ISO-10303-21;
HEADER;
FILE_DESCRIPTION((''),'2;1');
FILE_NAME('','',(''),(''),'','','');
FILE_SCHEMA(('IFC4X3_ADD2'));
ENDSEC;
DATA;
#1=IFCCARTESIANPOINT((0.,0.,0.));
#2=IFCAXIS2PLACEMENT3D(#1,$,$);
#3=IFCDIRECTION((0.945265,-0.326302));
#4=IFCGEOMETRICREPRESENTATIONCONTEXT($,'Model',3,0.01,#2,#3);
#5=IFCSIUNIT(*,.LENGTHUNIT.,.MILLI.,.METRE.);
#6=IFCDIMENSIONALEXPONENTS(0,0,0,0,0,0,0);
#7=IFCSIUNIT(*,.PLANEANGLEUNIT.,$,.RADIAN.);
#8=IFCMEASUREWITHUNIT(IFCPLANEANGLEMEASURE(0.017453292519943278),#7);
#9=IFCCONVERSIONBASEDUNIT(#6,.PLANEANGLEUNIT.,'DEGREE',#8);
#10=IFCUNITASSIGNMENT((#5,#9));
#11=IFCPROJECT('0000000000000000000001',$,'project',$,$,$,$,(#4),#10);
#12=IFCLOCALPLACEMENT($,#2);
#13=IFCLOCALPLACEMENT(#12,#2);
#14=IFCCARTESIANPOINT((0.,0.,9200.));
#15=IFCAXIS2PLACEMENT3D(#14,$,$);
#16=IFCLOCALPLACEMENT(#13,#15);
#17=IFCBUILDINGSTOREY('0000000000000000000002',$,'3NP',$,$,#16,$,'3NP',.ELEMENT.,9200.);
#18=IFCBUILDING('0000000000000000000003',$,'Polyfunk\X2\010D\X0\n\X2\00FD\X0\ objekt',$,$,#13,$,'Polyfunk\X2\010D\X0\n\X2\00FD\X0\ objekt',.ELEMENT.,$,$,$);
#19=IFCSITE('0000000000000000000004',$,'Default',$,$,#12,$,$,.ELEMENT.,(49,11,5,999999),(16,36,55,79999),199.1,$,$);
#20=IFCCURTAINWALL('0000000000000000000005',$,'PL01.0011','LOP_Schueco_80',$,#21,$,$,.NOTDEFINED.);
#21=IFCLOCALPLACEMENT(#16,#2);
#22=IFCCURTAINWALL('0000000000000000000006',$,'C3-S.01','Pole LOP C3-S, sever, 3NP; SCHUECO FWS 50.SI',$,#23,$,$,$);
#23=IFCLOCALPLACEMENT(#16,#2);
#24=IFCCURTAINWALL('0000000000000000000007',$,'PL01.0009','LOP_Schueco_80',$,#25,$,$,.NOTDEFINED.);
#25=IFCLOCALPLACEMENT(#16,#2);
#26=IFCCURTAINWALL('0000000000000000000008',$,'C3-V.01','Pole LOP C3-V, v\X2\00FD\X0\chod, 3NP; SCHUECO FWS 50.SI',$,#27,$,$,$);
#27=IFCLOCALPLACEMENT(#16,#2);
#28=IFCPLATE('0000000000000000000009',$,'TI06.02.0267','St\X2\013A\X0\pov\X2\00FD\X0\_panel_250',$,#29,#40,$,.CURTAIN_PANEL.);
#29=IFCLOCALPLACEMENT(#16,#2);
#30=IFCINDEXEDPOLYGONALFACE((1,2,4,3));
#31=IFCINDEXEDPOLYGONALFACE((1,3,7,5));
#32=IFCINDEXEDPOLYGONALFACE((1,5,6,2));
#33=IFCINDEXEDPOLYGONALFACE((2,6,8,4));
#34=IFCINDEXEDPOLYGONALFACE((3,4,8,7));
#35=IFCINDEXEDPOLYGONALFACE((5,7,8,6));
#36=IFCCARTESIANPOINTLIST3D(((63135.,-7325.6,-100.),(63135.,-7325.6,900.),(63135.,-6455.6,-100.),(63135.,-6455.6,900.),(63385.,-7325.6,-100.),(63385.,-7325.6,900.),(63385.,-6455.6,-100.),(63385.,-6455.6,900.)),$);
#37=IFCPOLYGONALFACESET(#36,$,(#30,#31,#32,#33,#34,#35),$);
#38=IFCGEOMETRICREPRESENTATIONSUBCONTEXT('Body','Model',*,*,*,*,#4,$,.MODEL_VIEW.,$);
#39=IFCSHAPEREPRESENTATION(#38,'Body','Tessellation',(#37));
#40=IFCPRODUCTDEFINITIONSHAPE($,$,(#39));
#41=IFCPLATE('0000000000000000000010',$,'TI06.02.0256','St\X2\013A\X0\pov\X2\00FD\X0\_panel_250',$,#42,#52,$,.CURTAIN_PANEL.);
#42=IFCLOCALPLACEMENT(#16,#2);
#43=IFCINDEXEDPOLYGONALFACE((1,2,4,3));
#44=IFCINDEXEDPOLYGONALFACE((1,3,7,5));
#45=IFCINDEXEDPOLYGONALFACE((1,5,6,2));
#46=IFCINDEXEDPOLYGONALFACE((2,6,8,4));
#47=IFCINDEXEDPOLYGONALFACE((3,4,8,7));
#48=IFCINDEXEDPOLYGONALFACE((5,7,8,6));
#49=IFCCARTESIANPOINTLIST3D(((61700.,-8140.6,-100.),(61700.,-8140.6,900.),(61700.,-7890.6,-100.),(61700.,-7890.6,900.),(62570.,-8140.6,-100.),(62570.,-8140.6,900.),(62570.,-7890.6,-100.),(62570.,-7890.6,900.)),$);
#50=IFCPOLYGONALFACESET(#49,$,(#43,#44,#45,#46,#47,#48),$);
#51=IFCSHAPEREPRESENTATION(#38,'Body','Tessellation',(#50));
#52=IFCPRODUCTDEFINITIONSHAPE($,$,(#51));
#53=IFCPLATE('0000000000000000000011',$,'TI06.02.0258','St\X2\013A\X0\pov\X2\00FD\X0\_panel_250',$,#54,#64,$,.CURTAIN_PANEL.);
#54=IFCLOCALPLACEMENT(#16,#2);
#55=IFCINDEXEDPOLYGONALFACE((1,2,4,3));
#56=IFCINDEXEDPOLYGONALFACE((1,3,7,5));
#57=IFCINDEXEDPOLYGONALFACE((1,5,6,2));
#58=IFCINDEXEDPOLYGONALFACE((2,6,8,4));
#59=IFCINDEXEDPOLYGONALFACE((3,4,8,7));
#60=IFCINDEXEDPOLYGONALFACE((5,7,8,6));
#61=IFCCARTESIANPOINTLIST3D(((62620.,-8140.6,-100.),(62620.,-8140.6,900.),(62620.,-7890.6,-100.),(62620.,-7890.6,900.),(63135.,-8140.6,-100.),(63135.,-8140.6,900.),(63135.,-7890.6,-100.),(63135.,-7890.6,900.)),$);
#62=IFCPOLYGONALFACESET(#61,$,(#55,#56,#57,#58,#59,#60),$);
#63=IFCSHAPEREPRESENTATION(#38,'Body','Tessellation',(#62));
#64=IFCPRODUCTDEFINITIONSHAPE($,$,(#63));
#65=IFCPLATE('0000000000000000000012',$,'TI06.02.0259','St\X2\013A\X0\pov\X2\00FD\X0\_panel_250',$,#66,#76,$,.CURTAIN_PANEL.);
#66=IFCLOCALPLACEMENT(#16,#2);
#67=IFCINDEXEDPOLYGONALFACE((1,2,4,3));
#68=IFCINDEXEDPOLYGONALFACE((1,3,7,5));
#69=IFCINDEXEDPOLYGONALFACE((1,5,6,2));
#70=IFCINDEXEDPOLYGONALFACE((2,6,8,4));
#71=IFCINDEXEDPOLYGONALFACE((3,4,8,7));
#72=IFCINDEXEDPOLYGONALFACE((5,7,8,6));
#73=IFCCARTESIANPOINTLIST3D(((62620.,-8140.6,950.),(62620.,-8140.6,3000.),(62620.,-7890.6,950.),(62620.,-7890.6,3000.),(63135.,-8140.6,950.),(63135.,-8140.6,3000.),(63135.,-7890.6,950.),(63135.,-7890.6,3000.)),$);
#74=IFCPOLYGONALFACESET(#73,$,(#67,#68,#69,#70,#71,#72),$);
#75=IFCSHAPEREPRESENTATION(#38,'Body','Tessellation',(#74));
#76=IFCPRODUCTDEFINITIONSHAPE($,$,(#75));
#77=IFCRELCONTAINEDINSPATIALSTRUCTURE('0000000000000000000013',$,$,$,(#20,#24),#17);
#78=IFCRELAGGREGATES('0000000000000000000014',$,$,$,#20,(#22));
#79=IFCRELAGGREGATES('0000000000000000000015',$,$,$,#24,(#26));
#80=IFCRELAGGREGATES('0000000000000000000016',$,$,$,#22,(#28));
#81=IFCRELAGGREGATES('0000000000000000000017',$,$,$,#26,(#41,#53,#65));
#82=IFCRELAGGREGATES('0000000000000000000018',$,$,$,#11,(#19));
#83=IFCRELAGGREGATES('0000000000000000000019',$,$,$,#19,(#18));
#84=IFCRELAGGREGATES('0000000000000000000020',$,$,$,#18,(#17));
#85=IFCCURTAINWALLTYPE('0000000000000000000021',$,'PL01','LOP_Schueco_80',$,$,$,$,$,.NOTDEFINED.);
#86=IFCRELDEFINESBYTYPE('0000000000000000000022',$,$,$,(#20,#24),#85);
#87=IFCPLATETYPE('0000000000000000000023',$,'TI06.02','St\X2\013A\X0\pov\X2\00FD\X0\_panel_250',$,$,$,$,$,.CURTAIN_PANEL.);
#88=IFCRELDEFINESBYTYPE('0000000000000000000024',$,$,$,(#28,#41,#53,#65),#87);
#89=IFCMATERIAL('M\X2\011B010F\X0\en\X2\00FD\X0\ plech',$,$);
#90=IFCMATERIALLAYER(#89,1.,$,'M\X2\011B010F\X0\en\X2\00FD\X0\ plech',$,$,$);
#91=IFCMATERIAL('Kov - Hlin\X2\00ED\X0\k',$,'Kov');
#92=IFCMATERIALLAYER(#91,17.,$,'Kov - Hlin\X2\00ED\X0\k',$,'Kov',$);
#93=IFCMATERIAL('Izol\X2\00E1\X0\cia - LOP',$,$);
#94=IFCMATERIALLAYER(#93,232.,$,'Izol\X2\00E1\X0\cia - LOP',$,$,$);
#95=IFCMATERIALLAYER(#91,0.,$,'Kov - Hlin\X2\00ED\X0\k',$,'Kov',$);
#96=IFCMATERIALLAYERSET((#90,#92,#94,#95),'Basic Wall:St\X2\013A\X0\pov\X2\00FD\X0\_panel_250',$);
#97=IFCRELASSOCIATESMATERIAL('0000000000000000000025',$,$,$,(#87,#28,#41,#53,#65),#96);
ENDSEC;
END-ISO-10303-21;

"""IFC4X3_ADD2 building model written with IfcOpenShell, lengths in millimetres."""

from ifc_helpers import new_model, entity, si_unit, converted_unit, direction, frame, frame_2d, origin, place, context, subcontext, project, spatial, rectangle, extrude, material, layer, layer_set, layer_usage, type_object, element, aggregate, save


model = new_model("IFC4X3_ADD2")

# Units and contexts
model_context = context("Model", 3, precision=0.01, world=origin(), true_north=direction((0.945265, -0.326302)))
body_context = subcontext(model_context, "Body", "Model", "MODEL_VIEW")
ifc_project = project(units=[si_unit("LENGTHUNIT", "METRE", prefix="MILLI"), converted_unit("PLANEANGLEUNIT", "DEGREE", entity("IfcPlaneAngleMeasure", 0.017453292519943278), si_unit("PLANEANGLEUNIT", "RADIAN"), dimensions=[0, 0, 0, 0, 0, 0, 0])], contexts=[model_context])

# Site, building, storey
site_placement = place(None, origin())
site = spatial("IfcSite", under=ifc_project, at=site_placement, Name="Default", CompositionType="ELEMENT", RefLatitude=(49, 11, 5, 999999), RefLongitude=(16, 36, 55, 79999), RefElevation=199.1)
building_placement = place(site_placement, origin())
building = spatial("IfcBuilding", under=site, at=building_placement, Name="Polyfunkčný objekt", LongName="Polyfunkčný objekt", CompositionType="ELEMENT")
storey_placement = place(building_placement, frame((0.0, 0.0, 9200.0)))
storey = spatial("IfcBuildingStorey", under=building, at=storey_placement, Name="3NP", LongName="3NP", CompositionType="ELEMENT", Elevation=9200.0)

# Curtain walls
curtain_wall_type = type_object("IfcCurtainWallType", Name="PL01", Description="LOP_Schueco_80", PredefinedType="NOTDEFINED")
curtain_wall_1_placement = place(storey_placement, frame((0.0, 0.0, -9200.0)))
curtain_wall_1 = element("IfcCurtainWall", 1, at=curtain_wall_1_placement, inside=storey, type_object=curtain_wall_type, Name="PL01.0011", Description="LOP_Schueco_80", PredefinedType="NOTDEFINED")
curtain_wall_2 = element("IfcCurtainWall", 2, Name="C3-S.01", Description="Pole LOP C3-S, sever, 3NP; SCHUECO FWS 50.SI")
aggregate(curtain_wall_1, [curtain_wall_2])
curtain_wall_3_placement = place(storey_placement, frame((0.0, 0.0, -9200.0)))
curtain_wall_3 = element("IfcCurtainWall", 3, at=curtain_wall_3_placement, inside=storey, type_object=curtain_wall_type, Name="PL01.0009", Description="LOP_Schueco_80", PredefinedType="NOTDEFINED")
curtain_wall_4 = element("IfcCurtainWall", 4, Name="C3-V.01", Description="Pole LOP C3-V, východ, 3NP; SCHUECO FWS 50.SI")
aggregate(curtain_wall_3, [curtain_wall_4])

# Plates
ifc_material_1 = material(Name="Měďený plech")
ifc_layer_1 = layer(ifc_material_1, 1.0, Name="Měďený plech")
ifc_material_2 = material(Name="Kov - Hliník", Category="Kov")
ifc_layer_2 = layer(ifc_material_2, 17.0, Name="Kov - Hliník", Category="Kov")
ifc_material_3 = material(Name="Izolácia - LOP")
ifc_layer_3 = layer(ifc_material_3, 232.0, Name="Izolácia - LOP")
ifc_layer_4 = layer(ifc_material_2, 0.0, Name="Kov - Hliník", Category="Kov")
ifc_layer_set = layer_set([ifc_layer_1, ifc_layer_2, ifc_layer_3, ifc_layer_4], Name="Basic Wall:Stĺpový_panel_250")
ifc_layer_usage_1 = layer_usage(ifc_layer_set, "AXIS2", "NEGATIVE", 125.0)
plate_type = type_object("IfcPlateType", Name="TI06.02", Description="Stĺpový_panel_250", PredefinedType="CURTAIN_PANEL", material=ifc_layer_set)
plate_1_placement = place(storey_placement, frame((63260.0, -6455.6, -100.0), z_axis=(0.0, 0.0, 1.0), x_axis=(0.0, -1.0, 0.0)))
plate_1 = element("IfcPlate", 5, at=plate_1_placement, type_object=plate_type, material=ifc_layer_usage_1, Name="TI06.02.0267", Description="Stĺpový_panel_250", PredefinedType="CURTAIN_PANEL", context=body_context, shape_type="SweptSolid", body=[
    extrude(rectangle(XDim=250.0, YDim=870.0, at=frame_2d((0.0, 0.0), x_axis=(1.0, 0.0))), frame((435.0, 0.0, 0.0), z_axis=(0.0, 0.0, 1.0), x_axis=(0.0, 1.0, 0.0)), (0.0, 0.0, 1.0), 1000.0),
])
aggregate(curtain_wall_2, [plate_1])
ifc_layer_usage_2 = layer_usage(ifc_layer_set, "AXIS2", "POSITIVE", -125.0)
plate_2_placement = place(storey_placement, frame((61700.0, -8015.6, -100.0)))
plate_2 = element("IfcPlate", 6, at=plate_2_placement, type_object=plate_type, material=ifc_layer_usage_2, Name="TI06.02.0256", Description="Stĺpový_panel_250", PredefinedType="CURTAIN_PANEL", context=body_context, shape_type="SweptSolid", body=[
    extrude(rectangle(XDim=250.0, YDim=870.0, at=frame_2d((0.0, 0.0), x_axis=(1.0, 0.0))), frame((435.0, 0.0, 0.0), z_axis=(0.0, 0.0, 1.0), x_axis=(0.0, 1.0, 0.0)), (0.0, 0.0, 1.0), 1000.0),
])
ifc_layer_usage_3 = layer_usage(ifc_layer_set, "AXIS2", "POSITIVE", -125.0)
plate_3_placement = place(storey_placement, frame((62620.0, -8015.6, -100.0)))
plate_3 = element("IfcPlate", 7, at=plate_3_placement, type_object=plate_type, material=ifc_layer_usage_3, Name="TI06.02.0258", Description="Stĺpový_panel_250", PredefinedType="CURTAIN_PANEL", context=body_context, shape_type="SweptSolid", body=[
    extrude(rectangle(XDim=250.0, YDim=515.0, at=frame_2d((0.0, 0.0), x_axis=(1.0, 0.0))), frame((257.5, 0.0, 0.0), z_axis=(0.0, 0.0, 1.0), x_axis=(0.0, 1.0, 0.0)), (0.0, 0.0, 1.0), 1000.0),
])
ifc_layer_usage_4 = layer_usage(ifc_layer_set, "AXIS2", "POSITIVE", -125.0)
plate_4_placement = place(storey_placement, frame((62620.0, -8015.6, 950.0)))
plate_4 = element("IfcPlate", 8, at=plate_4_placement, type_object=plate_type, material=ifc_layer_usage_4, Name="TI06.02.0259", Description="Stĺpový_panel_250", PredefinedType="CURTAIN_PANEL", context=body_context, shape_type="SweptSolid", body=[
    extrude(rectangle(XDim=250.0, YDim=515.0, at=frame_2d((0.0, 0.0), x_axis=(1.0, 0.0))), frame((257.5, 0.0, 0.0), z_axis=(0.0, 0.0, 1.0), x_axis=(0.0, 1.0, 0.0)), (0.0, 0.0, 1.0), 2050.0),
])
aggregate(curtain_wall_4, [plate_2, plate_3, plate_4])

save(model, "model.ifc")
